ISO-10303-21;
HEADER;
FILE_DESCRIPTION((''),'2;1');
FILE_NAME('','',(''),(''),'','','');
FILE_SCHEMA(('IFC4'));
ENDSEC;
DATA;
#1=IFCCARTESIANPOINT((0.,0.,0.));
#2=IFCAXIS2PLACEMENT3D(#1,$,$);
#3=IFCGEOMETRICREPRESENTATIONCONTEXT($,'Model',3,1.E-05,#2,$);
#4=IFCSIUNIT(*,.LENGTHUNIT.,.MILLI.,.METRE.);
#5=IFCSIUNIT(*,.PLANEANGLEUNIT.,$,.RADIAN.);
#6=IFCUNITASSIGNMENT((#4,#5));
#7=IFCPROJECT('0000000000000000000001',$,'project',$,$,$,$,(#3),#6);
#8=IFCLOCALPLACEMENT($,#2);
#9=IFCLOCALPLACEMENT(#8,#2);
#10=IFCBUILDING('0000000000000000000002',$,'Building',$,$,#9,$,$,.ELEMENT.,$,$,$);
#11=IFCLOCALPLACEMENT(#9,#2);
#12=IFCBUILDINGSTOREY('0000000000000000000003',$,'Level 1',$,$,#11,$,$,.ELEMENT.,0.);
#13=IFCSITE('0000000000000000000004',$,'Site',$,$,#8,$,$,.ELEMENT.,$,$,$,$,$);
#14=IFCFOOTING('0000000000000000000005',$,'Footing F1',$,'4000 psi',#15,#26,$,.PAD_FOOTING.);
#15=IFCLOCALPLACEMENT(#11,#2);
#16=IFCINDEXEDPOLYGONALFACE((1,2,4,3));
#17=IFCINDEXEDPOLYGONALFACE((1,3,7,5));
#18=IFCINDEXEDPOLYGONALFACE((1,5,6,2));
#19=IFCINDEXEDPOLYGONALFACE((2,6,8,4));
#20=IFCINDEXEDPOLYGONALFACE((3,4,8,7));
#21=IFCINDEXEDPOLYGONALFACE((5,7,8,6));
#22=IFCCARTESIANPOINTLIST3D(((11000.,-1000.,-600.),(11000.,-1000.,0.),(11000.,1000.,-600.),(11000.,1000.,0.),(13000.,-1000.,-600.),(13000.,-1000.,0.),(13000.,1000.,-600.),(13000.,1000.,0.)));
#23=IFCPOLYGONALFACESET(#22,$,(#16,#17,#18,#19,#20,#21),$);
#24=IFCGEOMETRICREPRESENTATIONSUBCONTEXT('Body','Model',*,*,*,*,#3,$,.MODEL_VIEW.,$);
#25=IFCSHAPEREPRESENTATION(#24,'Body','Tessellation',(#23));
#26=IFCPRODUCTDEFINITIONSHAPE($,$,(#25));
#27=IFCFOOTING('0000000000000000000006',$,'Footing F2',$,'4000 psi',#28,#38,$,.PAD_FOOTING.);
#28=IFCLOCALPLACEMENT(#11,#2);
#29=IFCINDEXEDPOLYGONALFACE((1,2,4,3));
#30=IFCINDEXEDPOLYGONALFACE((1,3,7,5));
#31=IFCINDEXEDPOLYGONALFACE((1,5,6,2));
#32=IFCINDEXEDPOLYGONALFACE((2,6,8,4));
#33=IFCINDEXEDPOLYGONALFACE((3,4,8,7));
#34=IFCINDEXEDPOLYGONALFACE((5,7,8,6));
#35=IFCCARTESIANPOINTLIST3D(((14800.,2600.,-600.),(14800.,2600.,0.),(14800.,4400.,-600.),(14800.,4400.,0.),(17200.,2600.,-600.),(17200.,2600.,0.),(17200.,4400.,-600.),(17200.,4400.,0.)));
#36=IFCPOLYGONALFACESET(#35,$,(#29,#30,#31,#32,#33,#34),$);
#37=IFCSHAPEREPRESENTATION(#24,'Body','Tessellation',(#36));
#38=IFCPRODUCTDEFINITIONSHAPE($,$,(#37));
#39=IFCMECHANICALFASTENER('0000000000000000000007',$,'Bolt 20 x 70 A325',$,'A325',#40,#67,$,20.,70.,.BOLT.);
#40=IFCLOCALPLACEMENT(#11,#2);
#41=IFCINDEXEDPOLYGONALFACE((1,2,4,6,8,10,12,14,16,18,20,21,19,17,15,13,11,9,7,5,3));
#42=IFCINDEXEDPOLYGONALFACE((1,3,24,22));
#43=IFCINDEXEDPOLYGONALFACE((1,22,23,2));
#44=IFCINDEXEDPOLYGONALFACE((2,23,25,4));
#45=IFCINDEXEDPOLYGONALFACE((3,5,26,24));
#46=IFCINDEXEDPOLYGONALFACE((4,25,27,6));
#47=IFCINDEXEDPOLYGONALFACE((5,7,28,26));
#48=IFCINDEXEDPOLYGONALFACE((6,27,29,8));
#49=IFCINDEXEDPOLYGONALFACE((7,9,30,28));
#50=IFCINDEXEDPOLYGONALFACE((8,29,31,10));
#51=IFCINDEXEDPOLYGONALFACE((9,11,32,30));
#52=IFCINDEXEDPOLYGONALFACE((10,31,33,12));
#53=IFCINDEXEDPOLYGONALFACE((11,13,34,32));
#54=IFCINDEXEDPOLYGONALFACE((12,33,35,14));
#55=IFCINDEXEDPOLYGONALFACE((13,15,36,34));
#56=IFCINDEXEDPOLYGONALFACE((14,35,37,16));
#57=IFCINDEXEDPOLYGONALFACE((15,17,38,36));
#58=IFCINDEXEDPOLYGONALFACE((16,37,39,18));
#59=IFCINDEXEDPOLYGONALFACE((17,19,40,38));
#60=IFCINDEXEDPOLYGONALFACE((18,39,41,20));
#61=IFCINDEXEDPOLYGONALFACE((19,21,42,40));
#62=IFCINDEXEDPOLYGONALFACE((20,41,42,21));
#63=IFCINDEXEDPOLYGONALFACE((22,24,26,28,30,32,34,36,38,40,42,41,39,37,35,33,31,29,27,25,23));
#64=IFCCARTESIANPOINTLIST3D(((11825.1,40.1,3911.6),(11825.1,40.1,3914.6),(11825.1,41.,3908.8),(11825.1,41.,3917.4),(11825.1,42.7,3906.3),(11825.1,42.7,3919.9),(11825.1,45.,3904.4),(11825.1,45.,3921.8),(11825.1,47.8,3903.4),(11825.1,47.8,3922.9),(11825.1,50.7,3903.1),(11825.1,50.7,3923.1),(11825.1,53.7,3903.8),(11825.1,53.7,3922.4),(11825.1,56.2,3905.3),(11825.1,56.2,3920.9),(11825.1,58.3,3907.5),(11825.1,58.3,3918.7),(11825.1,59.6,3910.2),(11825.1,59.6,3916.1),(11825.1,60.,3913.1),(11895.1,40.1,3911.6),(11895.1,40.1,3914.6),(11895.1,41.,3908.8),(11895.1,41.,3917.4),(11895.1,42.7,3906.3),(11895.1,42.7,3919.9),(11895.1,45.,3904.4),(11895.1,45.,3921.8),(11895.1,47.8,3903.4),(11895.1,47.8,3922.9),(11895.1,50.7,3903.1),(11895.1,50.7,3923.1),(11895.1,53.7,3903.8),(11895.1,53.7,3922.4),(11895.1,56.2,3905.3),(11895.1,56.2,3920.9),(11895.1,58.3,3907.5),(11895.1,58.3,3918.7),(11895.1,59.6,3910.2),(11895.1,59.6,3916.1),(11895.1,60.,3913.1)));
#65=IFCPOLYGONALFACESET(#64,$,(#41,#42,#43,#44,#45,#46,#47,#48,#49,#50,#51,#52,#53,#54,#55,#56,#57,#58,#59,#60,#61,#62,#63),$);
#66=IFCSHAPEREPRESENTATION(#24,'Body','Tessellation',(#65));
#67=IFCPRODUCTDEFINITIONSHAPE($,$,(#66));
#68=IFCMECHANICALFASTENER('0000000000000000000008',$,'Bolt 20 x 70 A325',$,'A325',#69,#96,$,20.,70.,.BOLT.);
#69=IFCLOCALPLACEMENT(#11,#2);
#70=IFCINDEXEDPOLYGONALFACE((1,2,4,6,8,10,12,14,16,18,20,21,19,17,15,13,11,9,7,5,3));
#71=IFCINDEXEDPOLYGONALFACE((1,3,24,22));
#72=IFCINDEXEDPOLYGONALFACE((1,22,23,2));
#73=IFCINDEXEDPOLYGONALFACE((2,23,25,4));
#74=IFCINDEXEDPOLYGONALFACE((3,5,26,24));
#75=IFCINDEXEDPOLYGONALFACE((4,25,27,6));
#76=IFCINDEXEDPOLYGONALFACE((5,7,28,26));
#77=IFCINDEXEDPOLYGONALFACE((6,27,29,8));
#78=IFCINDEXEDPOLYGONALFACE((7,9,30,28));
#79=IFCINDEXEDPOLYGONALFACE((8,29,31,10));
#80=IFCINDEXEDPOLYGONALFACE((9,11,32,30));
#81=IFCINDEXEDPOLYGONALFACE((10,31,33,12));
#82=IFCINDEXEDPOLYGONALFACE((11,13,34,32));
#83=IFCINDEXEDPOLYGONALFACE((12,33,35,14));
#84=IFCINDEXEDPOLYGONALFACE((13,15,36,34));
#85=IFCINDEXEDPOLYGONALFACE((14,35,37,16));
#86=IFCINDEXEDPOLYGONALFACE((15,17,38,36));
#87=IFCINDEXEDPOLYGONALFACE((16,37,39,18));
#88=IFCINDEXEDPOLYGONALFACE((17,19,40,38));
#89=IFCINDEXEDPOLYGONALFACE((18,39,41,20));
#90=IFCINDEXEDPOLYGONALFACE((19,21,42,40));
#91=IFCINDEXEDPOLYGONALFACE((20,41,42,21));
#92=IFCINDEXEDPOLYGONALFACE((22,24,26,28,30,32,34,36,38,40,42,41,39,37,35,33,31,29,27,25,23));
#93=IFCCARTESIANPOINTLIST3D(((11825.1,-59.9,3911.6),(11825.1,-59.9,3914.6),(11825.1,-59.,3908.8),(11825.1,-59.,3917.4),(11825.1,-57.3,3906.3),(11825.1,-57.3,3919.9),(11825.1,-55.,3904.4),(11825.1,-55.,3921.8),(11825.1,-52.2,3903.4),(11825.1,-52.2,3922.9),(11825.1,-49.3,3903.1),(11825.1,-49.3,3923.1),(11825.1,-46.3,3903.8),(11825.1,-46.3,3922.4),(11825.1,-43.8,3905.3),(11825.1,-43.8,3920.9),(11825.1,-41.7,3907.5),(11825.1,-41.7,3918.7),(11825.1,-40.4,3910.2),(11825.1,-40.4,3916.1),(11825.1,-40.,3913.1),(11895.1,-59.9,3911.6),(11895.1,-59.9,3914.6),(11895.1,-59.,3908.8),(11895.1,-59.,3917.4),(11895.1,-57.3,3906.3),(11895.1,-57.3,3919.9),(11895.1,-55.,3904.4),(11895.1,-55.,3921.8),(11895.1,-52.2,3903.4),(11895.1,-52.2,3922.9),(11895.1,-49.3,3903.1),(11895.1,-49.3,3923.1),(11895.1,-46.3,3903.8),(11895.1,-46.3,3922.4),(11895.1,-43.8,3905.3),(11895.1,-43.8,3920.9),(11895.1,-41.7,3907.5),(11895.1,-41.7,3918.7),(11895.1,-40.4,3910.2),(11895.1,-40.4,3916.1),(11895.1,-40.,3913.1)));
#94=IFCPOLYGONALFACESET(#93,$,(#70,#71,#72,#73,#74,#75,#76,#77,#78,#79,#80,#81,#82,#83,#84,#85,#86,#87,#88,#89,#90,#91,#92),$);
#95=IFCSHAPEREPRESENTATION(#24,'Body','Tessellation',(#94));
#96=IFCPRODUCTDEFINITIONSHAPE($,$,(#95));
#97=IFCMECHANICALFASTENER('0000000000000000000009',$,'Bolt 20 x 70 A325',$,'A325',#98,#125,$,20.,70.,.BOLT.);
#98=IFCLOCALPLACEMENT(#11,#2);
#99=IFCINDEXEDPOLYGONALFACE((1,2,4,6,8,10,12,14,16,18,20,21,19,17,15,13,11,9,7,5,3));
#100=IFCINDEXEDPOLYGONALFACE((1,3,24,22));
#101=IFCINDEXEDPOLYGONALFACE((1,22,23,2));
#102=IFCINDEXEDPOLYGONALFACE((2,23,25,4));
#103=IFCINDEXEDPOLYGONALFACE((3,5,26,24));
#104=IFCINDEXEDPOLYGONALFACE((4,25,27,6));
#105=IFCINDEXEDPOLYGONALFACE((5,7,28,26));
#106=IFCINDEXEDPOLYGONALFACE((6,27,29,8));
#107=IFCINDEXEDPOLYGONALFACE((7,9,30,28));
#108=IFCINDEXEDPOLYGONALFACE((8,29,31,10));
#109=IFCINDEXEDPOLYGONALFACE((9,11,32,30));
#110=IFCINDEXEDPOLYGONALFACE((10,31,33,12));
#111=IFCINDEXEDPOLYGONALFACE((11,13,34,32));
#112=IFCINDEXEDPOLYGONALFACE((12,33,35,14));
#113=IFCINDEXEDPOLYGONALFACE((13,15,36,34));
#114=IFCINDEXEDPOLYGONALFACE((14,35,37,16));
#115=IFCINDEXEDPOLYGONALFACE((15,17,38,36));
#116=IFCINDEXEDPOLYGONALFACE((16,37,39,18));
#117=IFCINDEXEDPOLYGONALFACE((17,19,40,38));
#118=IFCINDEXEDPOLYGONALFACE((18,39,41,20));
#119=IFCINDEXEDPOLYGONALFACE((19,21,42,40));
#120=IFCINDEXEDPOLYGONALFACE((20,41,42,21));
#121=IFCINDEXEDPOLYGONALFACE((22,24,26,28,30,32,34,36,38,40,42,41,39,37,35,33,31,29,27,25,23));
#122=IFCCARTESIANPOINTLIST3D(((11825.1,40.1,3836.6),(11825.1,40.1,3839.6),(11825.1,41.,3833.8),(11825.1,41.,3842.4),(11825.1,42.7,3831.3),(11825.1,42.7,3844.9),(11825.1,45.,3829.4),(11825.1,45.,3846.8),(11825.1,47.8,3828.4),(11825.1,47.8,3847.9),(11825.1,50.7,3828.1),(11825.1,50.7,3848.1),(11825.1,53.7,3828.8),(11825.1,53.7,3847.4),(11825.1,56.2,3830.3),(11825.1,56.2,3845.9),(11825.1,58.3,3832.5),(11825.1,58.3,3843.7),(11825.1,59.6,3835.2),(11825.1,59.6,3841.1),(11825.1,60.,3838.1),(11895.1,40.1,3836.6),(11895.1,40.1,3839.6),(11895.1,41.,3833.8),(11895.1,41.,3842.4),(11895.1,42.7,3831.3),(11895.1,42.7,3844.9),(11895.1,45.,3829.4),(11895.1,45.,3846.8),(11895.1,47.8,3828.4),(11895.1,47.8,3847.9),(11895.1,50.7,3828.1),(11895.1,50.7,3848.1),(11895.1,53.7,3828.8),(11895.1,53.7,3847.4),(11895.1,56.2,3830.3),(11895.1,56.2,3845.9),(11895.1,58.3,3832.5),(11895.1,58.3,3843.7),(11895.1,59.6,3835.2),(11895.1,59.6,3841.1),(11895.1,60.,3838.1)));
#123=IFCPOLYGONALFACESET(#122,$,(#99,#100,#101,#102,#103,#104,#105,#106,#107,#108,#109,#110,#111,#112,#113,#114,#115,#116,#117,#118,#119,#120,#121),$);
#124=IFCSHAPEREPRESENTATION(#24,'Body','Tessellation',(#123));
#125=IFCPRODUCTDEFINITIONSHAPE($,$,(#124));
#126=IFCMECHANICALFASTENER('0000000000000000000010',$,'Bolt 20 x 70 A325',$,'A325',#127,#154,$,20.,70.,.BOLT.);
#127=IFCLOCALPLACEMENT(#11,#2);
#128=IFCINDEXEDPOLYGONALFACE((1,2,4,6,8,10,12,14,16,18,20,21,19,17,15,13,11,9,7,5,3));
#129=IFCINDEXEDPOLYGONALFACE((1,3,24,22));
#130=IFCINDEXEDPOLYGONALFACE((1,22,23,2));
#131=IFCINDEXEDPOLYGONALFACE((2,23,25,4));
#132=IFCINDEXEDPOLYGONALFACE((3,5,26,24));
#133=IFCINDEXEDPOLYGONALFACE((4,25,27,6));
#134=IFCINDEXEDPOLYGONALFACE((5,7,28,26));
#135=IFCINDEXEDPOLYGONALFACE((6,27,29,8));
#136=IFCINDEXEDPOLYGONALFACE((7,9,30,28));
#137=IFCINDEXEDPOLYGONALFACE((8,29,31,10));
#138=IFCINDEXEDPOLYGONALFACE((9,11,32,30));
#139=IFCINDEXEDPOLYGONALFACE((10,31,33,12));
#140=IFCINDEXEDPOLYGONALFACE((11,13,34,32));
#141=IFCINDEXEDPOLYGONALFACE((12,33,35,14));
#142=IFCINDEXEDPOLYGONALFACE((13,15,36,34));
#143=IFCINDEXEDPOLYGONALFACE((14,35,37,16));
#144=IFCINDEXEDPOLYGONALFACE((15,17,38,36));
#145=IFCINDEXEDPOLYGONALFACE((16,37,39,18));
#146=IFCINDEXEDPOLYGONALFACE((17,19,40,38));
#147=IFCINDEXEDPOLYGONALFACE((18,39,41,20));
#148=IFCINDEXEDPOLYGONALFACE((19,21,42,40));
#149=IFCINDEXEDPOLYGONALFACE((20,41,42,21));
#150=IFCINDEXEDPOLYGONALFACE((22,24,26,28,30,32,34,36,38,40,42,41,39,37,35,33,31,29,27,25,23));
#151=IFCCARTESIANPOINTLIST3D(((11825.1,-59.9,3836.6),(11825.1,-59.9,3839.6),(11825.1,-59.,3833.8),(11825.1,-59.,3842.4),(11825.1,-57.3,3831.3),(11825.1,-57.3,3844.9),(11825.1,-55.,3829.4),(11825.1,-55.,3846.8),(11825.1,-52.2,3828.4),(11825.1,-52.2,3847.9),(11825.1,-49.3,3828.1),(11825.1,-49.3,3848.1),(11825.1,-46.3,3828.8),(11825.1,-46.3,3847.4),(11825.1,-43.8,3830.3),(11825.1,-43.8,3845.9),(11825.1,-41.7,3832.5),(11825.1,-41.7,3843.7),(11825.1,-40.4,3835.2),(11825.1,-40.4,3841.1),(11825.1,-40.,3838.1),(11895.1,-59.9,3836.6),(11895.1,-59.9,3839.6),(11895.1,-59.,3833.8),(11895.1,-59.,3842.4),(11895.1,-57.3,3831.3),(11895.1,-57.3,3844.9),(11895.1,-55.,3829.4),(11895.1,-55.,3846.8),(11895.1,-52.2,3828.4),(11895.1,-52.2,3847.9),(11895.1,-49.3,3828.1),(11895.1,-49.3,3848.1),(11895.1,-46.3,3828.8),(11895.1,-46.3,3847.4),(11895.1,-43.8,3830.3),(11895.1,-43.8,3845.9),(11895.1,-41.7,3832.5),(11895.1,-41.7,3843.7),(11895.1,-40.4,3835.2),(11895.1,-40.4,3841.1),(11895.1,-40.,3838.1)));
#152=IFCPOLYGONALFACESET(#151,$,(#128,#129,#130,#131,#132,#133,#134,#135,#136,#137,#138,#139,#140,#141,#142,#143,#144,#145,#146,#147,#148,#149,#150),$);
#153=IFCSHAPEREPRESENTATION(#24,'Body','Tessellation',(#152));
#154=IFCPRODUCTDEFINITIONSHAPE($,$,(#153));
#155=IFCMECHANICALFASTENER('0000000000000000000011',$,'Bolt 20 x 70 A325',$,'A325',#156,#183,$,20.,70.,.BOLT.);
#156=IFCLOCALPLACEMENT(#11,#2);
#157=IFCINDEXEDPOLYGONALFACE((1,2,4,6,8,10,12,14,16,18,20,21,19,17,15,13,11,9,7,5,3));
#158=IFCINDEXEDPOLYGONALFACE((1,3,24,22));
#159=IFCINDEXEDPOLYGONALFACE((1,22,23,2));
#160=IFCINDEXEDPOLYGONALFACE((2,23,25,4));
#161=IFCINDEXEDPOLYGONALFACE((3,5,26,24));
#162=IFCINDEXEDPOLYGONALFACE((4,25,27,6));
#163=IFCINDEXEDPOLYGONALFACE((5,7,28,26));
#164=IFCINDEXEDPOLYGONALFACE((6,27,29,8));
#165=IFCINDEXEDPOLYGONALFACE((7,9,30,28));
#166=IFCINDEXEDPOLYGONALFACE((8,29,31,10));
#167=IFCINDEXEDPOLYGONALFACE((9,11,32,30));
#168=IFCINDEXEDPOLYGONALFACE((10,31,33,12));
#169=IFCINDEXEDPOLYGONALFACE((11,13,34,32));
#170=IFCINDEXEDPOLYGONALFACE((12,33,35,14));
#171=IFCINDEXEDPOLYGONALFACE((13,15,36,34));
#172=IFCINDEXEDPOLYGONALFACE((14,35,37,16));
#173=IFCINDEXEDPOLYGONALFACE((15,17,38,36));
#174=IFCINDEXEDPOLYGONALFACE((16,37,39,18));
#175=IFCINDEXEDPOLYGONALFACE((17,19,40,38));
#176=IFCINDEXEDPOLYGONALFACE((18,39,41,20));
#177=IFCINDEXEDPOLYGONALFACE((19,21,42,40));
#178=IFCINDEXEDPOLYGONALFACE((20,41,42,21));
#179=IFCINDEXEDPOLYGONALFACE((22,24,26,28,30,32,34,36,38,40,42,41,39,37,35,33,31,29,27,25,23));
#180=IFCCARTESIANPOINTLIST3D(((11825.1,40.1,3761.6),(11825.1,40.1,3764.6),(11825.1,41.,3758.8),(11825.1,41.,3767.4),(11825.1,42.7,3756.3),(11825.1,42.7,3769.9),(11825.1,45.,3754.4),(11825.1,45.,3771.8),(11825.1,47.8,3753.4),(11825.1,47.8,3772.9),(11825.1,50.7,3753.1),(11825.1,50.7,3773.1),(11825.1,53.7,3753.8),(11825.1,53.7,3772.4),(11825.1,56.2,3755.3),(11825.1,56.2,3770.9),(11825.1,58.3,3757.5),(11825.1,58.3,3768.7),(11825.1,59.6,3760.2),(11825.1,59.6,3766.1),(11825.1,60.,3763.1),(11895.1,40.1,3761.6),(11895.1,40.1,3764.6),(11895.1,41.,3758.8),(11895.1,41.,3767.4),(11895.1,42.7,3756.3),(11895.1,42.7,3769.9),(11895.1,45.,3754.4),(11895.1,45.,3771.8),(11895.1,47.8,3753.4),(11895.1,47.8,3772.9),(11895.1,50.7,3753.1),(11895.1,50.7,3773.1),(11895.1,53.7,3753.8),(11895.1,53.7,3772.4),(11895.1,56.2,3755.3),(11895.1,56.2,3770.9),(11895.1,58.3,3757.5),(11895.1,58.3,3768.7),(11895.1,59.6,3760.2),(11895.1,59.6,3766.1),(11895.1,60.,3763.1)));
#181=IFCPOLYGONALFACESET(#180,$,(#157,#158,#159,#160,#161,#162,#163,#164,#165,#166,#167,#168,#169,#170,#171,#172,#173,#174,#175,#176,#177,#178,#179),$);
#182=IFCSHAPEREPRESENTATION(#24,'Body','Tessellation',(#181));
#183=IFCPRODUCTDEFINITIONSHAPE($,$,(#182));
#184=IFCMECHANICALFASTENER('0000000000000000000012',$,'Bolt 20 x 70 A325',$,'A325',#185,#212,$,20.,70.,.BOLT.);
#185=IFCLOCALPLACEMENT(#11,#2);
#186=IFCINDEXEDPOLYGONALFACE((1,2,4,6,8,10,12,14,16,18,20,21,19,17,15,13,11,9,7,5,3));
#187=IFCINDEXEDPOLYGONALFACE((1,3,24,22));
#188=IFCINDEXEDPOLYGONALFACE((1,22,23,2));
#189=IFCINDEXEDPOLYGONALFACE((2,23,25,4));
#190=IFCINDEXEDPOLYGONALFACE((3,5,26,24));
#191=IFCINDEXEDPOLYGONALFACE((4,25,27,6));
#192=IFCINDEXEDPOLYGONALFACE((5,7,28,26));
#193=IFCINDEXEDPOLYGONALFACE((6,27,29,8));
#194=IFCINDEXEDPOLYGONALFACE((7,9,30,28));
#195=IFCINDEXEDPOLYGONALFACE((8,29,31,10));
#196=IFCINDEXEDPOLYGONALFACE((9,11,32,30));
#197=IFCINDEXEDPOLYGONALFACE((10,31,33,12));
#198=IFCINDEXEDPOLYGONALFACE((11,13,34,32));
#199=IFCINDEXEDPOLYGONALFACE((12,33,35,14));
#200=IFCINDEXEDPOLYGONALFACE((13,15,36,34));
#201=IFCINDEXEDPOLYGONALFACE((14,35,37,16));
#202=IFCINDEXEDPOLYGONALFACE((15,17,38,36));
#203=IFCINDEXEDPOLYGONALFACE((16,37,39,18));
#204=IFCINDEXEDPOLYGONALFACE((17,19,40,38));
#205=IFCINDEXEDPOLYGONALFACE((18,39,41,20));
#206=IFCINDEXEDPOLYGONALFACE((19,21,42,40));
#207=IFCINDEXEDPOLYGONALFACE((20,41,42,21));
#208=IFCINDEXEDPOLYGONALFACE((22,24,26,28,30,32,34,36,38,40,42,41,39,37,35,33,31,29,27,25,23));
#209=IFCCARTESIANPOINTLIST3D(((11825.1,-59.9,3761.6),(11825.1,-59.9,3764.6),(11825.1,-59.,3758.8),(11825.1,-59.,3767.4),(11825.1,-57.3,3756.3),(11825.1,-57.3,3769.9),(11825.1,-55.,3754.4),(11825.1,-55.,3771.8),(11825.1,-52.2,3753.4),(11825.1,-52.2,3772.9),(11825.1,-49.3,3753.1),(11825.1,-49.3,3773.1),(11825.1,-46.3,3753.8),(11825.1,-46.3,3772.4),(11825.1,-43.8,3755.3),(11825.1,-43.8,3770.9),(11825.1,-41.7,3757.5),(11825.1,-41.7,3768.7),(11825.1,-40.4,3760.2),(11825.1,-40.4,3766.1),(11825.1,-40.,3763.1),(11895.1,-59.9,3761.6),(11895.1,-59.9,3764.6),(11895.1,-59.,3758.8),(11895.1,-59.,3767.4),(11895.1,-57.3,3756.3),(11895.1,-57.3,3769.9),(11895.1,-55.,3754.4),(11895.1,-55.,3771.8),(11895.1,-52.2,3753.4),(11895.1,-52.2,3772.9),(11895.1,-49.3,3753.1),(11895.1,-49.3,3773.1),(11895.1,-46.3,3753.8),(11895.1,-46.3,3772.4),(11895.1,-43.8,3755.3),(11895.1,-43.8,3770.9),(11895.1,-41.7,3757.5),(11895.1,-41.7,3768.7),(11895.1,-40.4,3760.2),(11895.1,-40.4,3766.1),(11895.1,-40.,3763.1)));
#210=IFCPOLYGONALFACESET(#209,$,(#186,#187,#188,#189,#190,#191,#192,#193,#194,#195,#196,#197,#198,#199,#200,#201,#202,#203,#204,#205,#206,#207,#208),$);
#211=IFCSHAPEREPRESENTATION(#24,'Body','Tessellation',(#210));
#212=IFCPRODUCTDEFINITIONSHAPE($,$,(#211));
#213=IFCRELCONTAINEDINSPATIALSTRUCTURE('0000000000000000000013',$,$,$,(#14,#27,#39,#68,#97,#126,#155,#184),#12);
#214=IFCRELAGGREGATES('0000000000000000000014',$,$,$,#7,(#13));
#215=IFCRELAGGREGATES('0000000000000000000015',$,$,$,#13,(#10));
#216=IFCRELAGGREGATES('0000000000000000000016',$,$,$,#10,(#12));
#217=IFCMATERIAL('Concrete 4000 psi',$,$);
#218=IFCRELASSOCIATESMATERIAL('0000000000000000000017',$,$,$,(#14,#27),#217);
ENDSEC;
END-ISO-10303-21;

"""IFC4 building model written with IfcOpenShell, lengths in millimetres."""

from ifc_helpers import new_model, si_unit, frame, origin, origin_2d, place, context, subcontext, project, spatial, rectangle, circle, extrude, material, element, save


model = new_model("IFC4")

# Units and contexts
model_context = context("Model", 3, precision=1e-05, world=origin())
body_context = subcontext(model_context, "Body", "Model", "MODEL_VIEW")
ifc_project = project(units=[si_unit("LENGTHUNIT", "METRE", prefix="MILLI"), si_unit("PLANEANGLEUNIT", "RADIAN")], contexts=[model_context])

# Site, building, storey
site_placement = place(None, origin())
site = spatial("IfcSite", under=ifc_project, at=site_placement, Name="Site", CompositionType="ELEMENT")
building_placement = place(site_placement, origin())
building = spatial("IfcBuilding", under=site, at=building_placement, Name="Building", CompositionType="ELEMENT")
storey_placement = place(building_placement, origin())
storey = spatial("IfcBuildingStorey", under=building, at=storey_placement, Name="Level 1", CompositionType="ELEMENT", Elevation=0.0)

# Footings
ifc_material_1 = material(Name="Concrete 4000 psi")
footing_1_placement = place(storey_placement, frame((12000.0, 0.0, -600.0), z_axis=(0.0, 0.0, 1.0), x_axis=(1.0, 0.0, 0.0)))
element("IfcFooting", 1, at=footing_1_placement, inside=storey, material=ifc_material_1, Name="Footing F1", ObjectType="4000 psi", PredefinedType="PAD_FOOTING", context=body_context, shape_type="SweptSolid", body=[
    extrude(rectangle(XDim=2000.0, YDim=2000.0, at=origin_2d()), origin(), (0.0, 0.0, 1.0), 600.0),
])
footing_2_placement = place(storey_placement, frame((16000.0, 3500.0, -600.0), z_axis=(0.0, 0.0, 1.0), x_axis=(1.0, 0.0, 0.0)))
element("IfcFooting", 2, at=footing_2_placement, inside=storey, material=ifc_material_1, Name="Footing F2", ObjectType="4000 psi", PredefinedType="PAD_FOOTING", context=body_context, shape_type="SweptSolid", body=[
    extrude(rectangle(XDim=2400.0, YDim=1800.0, at=origin_2d()), origin(), (0.0, 0.0, 1.0), 600.0),
])

# Mechanical fasteners
for number, where, z_axis, x_axis, name in (
    (3, (11825.1, 50.0, 3913.1), (1.0, 0.0, 0.0), (0.0, 1.0, 0.0), "Bolt 20 x 70 A325"),
    (4, (11825.1, -50.0, 3913.1), (1.0, 0.0, 0.0), (0.0, 1.0, 0.0), "Bolt 20 x 70 A325"),
    (5, (11825.1, 50.0, 3838.1), (1.0, 0.0, 0.0), (0.0, 1.0, 0.0), "Bolt 20 x 70 A325"),
    (6, (11825.1, -50.0, 3838.1), (1.0, 0.0, 0.0), (0.0, 1.0, 0.0), "Bolt 20 x 70 A325"),
    (7, (11825.1, 50.0, 3763.1), (1.0, 0.0, 0.0), (0.0, 1.0, 0.0), "Bolt 20 x 70 A325"),
    (8, (11825.1, -50.0, 3763.1), (1.0, 0.0, 0.0), (0.0, 1.0, 0.0), "Bolt 20 x 70 A325"),
):
    element("IfcMechanicalFastener", number, at=place(storey_placement, frame(where, z_axis=z_axis, x_axis=x_axis)), inside=storey, Name=name, ObjectType="A325", NominalDiameter=20.0, NominalLength=70.0, PredefinedType="BOLT", context=body_context, shape_type="SweptSolid", body=[
        extrude(circle(Radius=10.0, at=origin_2d()), origin(), (0.0, 0.0, 1.0), 70.0),
    ])

save(model, "model.ifc")
